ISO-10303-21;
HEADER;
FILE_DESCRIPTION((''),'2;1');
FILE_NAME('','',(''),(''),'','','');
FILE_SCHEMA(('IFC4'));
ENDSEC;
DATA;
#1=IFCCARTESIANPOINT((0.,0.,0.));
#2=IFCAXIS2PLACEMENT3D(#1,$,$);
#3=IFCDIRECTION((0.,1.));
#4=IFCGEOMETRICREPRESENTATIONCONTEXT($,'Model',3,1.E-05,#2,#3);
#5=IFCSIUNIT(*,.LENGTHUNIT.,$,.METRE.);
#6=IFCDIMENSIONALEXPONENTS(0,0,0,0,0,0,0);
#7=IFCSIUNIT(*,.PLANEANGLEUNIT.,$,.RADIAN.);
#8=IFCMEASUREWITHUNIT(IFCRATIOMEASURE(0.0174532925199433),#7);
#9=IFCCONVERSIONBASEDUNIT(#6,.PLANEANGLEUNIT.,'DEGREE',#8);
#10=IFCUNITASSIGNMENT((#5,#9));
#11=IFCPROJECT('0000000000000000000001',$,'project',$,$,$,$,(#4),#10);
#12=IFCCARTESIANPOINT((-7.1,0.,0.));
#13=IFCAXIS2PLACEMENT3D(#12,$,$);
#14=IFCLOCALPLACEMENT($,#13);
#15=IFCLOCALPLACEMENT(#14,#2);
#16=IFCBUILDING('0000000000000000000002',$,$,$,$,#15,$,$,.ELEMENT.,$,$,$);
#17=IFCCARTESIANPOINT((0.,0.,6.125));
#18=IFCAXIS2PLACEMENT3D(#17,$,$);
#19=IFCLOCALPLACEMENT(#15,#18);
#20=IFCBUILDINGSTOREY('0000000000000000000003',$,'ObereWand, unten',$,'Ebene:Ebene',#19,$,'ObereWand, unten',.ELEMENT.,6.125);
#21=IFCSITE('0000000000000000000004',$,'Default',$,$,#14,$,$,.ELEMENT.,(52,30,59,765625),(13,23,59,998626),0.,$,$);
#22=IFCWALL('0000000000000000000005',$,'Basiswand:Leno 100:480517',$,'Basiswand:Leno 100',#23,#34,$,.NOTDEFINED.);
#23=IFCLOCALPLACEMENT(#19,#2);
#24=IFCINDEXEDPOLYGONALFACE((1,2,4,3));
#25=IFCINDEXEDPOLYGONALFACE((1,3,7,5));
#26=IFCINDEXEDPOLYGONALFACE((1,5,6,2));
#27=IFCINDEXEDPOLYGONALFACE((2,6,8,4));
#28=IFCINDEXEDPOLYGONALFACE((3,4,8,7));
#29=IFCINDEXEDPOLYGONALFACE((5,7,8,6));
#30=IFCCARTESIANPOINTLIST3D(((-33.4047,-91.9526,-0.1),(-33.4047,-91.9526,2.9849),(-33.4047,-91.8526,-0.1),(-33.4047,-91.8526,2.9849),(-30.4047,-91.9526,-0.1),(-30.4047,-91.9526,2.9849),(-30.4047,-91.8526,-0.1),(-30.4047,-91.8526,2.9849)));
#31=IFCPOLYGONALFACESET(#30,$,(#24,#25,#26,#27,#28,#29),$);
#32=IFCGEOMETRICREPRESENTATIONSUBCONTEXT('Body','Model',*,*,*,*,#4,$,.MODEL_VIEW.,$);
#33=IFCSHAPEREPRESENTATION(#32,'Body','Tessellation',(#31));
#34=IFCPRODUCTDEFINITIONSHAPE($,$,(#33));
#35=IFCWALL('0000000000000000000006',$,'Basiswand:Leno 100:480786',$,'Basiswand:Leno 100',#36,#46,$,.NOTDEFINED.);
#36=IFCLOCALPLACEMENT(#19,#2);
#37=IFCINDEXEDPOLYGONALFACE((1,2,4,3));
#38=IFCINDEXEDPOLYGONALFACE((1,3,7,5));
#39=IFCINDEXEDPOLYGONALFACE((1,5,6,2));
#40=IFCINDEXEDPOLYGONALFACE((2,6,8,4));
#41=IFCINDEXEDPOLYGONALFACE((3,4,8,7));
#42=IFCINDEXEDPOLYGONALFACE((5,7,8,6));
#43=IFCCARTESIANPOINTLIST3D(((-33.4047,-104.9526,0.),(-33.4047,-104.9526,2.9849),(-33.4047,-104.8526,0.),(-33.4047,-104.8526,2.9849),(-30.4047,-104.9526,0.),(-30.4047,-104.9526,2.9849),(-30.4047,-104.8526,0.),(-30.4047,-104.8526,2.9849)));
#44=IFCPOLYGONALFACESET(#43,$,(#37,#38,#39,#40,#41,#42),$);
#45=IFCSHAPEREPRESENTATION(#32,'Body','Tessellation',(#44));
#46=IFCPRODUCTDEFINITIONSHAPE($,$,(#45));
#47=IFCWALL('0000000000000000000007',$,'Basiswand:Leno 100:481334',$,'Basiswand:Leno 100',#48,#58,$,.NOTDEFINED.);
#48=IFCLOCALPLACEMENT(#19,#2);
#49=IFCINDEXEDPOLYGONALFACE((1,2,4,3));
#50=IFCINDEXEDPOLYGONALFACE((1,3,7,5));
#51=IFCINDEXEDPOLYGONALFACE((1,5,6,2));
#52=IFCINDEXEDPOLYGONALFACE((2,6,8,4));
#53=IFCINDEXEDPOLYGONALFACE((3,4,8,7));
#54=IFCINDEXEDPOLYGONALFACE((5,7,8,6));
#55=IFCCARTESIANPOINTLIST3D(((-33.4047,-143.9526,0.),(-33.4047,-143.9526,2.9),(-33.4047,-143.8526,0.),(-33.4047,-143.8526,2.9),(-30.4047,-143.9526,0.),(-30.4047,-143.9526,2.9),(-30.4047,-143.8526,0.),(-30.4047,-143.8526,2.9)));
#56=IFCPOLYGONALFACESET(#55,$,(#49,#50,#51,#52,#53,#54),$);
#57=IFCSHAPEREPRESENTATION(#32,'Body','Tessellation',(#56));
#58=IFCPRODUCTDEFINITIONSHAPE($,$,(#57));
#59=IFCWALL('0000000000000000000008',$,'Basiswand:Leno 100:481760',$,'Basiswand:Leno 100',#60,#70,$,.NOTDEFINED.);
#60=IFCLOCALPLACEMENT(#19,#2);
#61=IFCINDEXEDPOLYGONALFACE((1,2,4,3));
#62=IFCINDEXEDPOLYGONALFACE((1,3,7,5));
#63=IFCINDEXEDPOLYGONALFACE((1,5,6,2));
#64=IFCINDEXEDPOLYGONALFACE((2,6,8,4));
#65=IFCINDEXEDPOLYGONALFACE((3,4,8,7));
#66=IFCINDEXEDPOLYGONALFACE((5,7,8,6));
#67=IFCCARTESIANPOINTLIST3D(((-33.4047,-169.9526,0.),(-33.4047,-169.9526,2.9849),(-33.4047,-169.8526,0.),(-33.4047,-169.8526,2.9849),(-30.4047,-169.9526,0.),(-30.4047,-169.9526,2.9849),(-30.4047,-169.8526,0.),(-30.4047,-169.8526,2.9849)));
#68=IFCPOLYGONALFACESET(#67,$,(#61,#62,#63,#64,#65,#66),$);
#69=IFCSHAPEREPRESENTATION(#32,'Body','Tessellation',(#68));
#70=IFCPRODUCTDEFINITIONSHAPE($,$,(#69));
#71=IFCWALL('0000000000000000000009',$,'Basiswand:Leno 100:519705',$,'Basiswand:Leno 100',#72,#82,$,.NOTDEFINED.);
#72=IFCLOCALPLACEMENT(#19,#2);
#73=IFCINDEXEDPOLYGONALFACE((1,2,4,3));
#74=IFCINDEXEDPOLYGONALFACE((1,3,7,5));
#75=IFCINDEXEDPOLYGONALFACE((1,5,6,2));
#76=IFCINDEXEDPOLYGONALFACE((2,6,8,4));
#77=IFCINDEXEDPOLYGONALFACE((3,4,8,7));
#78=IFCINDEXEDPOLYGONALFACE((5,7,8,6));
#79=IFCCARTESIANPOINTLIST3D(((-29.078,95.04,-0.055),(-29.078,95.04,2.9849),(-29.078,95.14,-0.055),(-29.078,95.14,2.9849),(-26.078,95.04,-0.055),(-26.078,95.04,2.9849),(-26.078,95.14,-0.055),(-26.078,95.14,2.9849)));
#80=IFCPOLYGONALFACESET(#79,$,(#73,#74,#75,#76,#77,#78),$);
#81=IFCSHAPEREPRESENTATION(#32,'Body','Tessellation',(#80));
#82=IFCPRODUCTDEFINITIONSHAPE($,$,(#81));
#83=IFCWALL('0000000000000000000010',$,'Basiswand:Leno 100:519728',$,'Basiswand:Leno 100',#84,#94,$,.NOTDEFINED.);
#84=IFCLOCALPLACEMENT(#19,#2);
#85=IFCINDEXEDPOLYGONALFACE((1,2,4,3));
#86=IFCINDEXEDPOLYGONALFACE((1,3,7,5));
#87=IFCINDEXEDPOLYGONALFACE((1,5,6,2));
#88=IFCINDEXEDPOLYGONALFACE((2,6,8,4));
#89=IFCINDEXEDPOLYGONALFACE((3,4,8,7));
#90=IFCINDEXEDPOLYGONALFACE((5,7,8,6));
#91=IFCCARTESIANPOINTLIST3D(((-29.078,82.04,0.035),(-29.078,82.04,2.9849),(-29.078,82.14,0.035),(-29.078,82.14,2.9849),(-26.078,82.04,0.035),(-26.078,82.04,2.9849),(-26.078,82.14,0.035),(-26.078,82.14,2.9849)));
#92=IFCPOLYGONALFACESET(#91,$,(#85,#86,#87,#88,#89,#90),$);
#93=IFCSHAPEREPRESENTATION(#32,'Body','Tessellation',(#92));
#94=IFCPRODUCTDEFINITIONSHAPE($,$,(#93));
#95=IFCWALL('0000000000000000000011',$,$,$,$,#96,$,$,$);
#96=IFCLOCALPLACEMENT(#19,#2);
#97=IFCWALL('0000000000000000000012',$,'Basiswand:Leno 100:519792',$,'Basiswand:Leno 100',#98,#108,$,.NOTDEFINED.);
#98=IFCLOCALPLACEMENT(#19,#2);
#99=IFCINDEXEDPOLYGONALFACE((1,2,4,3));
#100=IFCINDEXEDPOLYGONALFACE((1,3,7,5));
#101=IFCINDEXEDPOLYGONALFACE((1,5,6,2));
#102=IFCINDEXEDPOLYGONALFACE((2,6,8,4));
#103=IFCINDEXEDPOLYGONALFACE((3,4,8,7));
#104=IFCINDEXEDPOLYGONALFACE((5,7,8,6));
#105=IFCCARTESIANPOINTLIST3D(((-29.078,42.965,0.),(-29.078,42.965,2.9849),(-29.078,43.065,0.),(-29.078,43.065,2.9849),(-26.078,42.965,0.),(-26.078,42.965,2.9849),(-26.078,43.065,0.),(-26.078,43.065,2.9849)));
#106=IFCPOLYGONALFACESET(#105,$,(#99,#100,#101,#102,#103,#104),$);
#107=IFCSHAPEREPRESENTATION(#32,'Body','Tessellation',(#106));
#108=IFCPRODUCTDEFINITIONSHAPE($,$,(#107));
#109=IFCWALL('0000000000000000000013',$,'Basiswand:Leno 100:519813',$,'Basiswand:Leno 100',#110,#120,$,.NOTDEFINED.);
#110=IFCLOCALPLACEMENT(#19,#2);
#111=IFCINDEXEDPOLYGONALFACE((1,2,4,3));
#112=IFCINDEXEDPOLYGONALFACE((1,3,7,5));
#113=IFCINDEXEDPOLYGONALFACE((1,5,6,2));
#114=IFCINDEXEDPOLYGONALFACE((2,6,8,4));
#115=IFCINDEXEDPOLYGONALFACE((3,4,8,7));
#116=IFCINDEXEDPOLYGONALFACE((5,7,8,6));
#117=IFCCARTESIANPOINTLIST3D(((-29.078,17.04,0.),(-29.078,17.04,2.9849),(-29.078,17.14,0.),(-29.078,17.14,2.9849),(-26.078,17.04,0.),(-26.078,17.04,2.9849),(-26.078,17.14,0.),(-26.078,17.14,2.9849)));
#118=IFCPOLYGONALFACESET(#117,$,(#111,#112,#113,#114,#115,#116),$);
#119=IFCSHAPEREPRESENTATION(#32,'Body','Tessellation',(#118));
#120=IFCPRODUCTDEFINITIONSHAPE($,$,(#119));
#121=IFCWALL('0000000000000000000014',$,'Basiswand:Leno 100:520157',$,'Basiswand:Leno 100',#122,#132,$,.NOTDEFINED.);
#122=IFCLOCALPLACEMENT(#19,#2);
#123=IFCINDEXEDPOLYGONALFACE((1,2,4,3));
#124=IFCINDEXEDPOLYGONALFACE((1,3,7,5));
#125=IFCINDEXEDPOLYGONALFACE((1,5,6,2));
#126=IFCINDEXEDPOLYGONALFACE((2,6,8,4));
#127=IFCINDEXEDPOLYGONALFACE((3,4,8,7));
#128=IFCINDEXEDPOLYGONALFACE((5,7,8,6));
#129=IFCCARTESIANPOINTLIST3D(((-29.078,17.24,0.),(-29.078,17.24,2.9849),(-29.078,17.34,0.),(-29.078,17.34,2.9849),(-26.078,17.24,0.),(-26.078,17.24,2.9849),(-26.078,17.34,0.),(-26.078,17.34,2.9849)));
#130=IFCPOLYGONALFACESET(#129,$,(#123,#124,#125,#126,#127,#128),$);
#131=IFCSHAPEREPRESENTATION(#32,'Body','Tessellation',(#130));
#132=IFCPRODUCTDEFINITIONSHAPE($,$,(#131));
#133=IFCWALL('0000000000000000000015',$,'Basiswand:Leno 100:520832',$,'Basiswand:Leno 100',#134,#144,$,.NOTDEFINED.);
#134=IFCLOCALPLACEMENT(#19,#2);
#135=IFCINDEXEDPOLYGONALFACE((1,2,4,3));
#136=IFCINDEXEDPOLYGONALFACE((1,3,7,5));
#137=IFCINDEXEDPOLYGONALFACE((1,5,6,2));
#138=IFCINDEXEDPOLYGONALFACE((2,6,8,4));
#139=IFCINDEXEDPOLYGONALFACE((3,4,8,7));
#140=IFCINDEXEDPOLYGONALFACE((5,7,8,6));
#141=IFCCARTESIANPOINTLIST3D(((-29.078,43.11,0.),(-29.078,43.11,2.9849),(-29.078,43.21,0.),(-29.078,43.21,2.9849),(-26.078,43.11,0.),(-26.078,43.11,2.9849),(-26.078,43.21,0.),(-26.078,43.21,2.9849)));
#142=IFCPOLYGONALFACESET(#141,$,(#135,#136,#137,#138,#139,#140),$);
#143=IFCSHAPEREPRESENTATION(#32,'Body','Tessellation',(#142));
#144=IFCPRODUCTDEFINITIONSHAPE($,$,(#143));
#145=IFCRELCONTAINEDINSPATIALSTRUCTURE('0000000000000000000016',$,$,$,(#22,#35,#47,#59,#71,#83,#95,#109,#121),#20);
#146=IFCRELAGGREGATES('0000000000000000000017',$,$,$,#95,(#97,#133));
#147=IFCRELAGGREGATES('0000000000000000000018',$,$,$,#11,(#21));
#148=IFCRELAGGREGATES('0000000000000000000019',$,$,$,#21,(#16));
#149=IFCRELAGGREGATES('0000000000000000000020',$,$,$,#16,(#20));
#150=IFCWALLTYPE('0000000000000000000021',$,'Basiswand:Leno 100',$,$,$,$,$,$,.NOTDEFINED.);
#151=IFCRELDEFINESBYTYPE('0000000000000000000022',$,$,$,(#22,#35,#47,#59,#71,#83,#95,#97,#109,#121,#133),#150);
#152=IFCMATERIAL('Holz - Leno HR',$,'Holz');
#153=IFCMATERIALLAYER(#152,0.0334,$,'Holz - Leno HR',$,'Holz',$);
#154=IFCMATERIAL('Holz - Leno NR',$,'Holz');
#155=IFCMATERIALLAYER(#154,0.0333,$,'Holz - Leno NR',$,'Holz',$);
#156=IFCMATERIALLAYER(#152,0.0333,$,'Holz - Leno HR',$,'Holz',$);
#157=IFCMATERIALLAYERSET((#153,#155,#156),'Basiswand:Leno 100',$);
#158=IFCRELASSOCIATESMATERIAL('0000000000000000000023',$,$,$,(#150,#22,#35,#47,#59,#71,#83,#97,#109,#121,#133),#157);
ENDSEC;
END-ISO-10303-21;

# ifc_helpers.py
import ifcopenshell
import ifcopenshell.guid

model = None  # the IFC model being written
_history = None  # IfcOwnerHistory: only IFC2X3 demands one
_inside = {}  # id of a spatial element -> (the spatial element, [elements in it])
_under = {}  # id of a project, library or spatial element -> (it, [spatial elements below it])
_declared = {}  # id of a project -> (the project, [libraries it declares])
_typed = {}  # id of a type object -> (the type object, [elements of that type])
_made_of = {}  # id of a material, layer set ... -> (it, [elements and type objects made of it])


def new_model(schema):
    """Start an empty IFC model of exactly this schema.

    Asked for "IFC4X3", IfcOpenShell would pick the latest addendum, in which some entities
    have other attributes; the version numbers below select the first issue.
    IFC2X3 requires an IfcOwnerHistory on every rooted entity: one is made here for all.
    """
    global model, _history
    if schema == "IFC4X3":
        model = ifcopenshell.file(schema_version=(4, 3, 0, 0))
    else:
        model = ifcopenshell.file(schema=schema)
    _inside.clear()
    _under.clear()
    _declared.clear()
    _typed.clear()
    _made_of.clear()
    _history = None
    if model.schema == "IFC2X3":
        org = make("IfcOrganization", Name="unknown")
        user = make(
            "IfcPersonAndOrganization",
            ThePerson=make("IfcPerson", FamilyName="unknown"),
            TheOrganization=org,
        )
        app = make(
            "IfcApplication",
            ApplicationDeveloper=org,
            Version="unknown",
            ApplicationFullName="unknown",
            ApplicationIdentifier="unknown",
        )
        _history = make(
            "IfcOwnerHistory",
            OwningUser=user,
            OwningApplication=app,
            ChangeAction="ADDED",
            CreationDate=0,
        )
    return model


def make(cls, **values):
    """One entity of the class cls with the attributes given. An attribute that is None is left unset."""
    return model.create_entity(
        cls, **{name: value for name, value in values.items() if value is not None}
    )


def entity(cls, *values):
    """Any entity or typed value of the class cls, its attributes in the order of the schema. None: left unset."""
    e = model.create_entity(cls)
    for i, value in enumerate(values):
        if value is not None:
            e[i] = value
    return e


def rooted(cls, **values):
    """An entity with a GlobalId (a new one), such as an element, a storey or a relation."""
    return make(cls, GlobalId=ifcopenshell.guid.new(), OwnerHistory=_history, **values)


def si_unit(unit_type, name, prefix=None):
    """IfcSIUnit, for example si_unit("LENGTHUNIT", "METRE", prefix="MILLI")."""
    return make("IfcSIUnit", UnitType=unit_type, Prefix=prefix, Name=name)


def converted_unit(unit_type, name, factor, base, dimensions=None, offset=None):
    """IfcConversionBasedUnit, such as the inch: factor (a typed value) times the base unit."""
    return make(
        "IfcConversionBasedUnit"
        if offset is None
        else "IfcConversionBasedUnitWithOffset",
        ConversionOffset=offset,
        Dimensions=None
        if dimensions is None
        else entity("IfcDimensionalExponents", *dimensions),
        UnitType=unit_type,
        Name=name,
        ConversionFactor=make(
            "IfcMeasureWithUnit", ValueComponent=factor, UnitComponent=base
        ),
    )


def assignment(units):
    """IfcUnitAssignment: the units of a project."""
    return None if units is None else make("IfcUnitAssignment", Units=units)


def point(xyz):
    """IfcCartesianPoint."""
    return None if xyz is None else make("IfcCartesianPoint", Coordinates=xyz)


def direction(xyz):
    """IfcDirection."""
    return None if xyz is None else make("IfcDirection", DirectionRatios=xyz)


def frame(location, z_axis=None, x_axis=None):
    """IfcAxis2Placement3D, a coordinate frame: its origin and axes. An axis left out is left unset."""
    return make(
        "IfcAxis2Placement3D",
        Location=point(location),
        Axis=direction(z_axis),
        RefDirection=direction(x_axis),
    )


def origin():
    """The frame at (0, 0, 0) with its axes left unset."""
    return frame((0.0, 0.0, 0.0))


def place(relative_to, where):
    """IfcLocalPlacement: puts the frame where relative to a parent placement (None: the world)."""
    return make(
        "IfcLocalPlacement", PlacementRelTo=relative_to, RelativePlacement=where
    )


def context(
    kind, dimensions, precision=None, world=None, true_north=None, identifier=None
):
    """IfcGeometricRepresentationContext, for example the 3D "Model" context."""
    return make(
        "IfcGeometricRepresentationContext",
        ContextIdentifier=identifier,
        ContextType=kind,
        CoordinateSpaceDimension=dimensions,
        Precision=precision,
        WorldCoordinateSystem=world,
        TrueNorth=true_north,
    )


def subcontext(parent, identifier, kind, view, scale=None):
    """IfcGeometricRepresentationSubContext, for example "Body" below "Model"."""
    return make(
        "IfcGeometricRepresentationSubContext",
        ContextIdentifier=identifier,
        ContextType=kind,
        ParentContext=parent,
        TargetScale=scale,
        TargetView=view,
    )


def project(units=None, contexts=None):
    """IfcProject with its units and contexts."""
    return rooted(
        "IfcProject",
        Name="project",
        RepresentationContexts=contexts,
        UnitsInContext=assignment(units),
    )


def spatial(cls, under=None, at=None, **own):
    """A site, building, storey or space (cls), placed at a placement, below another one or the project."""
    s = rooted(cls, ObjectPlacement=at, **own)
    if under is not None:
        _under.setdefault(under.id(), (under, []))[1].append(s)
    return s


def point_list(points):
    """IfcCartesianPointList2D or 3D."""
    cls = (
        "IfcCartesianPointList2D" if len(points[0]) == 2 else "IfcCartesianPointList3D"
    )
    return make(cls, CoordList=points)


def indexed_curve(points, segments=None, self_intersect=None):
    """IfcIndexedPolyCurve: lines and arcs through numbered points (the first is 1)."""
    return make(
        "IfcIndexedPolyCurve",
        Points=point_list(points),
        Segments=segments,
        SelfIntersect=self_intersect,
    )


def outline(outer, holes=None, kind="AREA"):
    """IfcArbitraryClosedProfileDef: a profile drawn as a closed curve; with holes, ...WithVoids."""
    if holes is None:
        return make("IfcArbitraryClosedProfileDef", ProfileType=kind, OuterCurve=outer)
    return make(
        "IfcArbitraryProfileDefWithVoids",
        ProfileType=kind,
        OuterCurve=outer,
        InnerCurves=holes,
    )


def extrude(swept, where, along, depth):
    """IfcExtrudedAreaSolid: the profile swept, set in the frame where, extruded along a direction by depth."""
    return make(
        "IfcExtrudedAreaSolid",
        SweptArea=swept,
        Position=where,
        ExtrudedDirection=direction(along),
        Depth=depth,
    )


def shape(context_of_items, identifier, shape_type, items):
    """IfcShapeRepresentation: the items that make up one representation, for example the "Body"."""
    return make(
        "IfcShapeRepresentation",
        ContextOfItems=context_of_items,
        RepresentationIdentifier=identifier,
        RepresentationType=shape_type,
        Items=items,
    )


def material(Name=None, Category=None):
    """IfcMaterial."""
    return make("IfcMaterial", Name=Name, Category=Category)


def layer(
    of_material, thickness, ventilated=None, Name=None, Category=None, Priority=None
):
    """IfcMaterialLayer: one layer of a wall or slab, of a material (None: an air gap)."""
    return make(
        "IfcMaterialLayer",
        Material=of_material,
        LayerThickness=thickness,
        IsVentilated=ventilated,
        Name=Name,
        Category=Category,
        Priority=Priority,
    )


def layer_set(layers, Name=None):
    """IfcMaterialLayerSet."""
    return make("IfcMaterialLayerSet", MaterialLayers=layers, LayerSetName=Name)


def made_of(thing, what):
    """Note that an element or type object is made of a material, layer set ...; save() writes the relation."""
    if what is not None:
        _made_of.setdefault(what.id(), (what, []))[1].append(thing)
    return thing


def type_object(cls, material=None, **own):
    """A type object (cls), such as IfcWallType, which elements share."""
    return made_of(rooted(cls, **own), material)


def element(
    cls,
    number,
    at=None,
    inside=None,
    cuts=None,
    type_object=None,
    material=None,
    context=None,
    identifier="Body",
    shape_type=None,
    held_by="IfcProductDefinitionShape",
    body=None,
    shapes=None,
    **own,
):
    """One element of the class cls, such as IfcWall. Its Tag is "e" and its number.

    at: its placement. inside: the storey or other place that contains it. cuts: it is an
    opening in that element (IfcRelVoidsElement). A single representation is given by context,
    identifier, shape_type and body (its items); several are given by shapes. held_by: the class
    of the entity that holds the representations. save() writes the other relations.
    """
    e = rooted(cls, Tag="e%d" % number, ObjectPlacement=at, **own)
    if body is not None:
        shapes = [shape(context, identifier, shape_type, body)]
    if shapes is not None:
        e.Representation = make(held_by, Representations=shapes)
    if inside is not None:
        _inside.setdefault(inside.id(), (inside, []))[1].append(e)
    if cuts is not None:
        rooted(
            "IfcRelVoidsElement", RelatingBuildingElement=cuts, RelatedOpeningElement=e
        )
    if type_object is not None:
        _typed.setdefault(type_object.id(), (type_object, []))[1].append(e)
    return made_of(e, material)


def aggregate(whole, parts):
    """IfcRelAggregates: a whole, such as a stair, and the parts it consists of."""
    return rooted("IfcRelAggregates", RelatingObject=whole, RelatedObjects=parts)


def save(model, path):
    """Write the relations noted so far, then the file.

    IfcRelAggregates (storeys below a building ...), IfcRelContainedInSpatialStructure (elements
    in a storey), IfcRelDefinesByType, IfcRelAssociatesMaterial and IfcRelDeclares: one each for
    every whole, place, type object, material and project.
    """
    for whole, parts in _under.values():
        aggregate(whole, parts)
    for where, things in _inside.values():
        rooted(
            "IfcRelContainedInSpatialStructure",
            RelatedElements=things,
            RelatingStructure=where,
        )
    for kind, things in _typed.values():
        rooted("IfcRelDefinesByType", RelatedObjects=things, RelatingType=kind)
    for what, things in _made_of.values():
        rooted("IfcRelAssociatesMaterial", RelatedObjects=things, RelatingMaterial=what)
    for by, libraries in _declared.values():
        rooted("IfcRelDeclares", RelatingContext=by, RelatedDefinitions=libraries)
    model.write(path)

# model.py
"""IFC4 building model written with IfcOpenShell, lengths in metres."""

from ifc_helpers import new_model, entity, si_unit, converted_unit, direction, frame, origin, place, context, subcontext, project, spatial, indexed_curve, outline, extrude, material, layer, layer_set, type_object, element, aggregate, save


model = new_model("IFC4")

# Units and contexts
model_context = context("Model", 3, precision=1e-05, world=origin(), true_north=direction((0.0, 1.0)))
body_context = subcontext(model_context, "Body", "Model", "MODEL_VIEW")
ifc_project = project(units=[si_unit("LENGTHUNIT", "METRE"), converted_unit("PLANEANGLEUNIT", "DEGREE", entity("IfcRatioMeasure", 0.0174532925199433), si_unit("PLANEANGLEUNIT", "RADIAN"), dimensions=[0, 0, 0, 0, 0, 0, 0])], contexts=[model_context])

# Site, building, storey
site_placement = place(None, frame((-7.1, 0.0, 0.0)))
site = spatial("IfcSite", under=ifc_project, at=site_placement, Name="Default", CompositionType="ELEMENT", RefLatitude=(52, 30, 59, 765625), RefLongitude=(13, 23, 59, 998626), RefElevation=0.0)
building_placement = place(site_placement, origin())
building = spatial("IfcBuilding", under=site, at=building_placement, CompositionType="ELEMENT")
storey_placement = place(building_placement, frame((0.0, 0.0, 6.125)))
storey = spatial("IfcBuildingStorey", under=building, at=storey_placement, Name="ObereWand, unten", ObjectType="Ebene:Ebene", LongName="ObereWand, unten", CompositionType="ELEMENT", Elevation=6.125)

# Shared definitions
ifc_material_1 = material(Name="Holz - Leno HR", Category="Holz")
ifc_material_2 = material(Name="Holz - Leno NR", Category="Holz")

# Walls
ifc_layer_1 = layer(ifc_material_1, 0.0334, Name="Holz - Leno HR", Category="Holz")
ifc_layer_2 = layer(ifc_material_2, 0.0333, Name="Holz - Leno NR", Category="Holz")
ifc_layer_3 = layer(ifc_material_1, 0.0333, Name="Holz - Leno HR", Category="Holz")
ifc_layer_set_1 = layer_set([ifc_layer_1, ifc_layer_2, ifc_layer_3], Name="Basiswand:Leno 100")
wall_type = type_object("IfcWallType", Name="Basiswand:Leno 100", PredefinedType="NOTDEFINED", material=ifc_layer_set_1)
wall_1_placement = place(storey_placement, frame((-30.4047, -91.9026, -0.1), z_axis=(0.0, 0.0, 1.0), x_axis=(-1.0, 0.0, 0.0)))
element("IfcWall", 1, at=wall_1_placement, inside=storey, type_object=wall_type, material=ifc_layer_set_1, Name="Basiswand:Leno 100:480517", ObjectType="Basiswand:Leno 100", PredefinedType="NOTDEFINED", context=body_context, shape_type="SweptSolid", body=[
    extrude(outline(indexed_curve([(3.0, 0.05), (0.0, 0.05), (0.0, -0.05), (3.0, -0.05), (3.0, 0.05)], self_intersect=False)), origin(), (0.0, 0.0, 1.0), 3.0849),
])
wall_2_placement = place(storey_placement, frame((-30.4047, -104.9026, 0.0), z_axis=(0.0, 0.0, 1.0), x_axis=(-1.0, 0.0, 0.0)))
element("IfcWall", 2, at=wall_2_placement, inside=storey, type_object=wall_type, material=ifc_layer_set_1, Name="Basiswand:Leno 100:480786", ObjectType="Basiswand:Leno 100", PredefinedType="NOTDEFINED", context=body_context, shape_type="SweptSolid", body=[
    extrude(outline(indexed_curve([(3.0, 0.05), (0.0, 0.05), (0.0, -0.05), (3.0, -0.05), (3.0, 0.05)], self_intersect=False)), origin(), (0.0, 0.0, 1.0), 2.9849),
])
wall_3_placement = place(storey_placement, frame((-30.4047, -143.9026, 0.0), z_axis=(0.0, 0.0, 1.0), x_axis=(-1.0, 0.0, 0.0)))
element("IfcWall", 3, at=wall_3_placement, inside=storey, type_object=wall_type, material=ifc_layer_set_1, Name="Basiswand:Leno 100:481334", ObjectType="Basiswand:Leno 100", PredefinedType="NOTDEFINED", context=body_context, shape_type="SweptSolid", body=[
    extrude(outline(indexed_curve([(3.0, 0.05), (0.0, 0.05), (0.0, -0.05), (3.0, -0.05), (3.0, 0.05)], self_intersect=False)), origin(), (0.0, 0.0, 1.0), 2.9),
])
wall_4_placement = place(storey_placement, frame((-30.4047, -169.9026, 0.0), z_axis=(0.0, 0.0, 1.0), x_axis=(-1.0, 0.0, 0.0)))
element("IfcWall", 4, at=wall_4_placement, inside=storey, type_object=wall_type, material=ifc_layer_set_1, Name="Basiswand:Leno 100:481760", ObjectType="Basiswand:Leno 100", PredefinedType="NOTDEFINED", context=body_context, shape_type="SweptSolid", body=[
    extrude(outline(indexed_curve([(3.0, 0.05), (0.0, 0.05), (0.0, -0.05), (3.0, -0.05), (3.0, 0.05)], self_intersect=False)), origin(), (0.0, 0.0, 1.0), 2.9849),
])
wall_5_placement = place(storey_placement, frame((-26.078, 95.09, -0.055), z_axis=(0.0, 0.0, 1.0), x_axis=(-1.0, 0.0, 0.0)))
element("IfcWall", 5, at=wall_5_placement, inside=storey, type_object=wall_type, material=ifc_layer_set_1, Name="Basiswand:Leno 100:519705", ObjectType="Basiswand:Leno 100", PredefinedType="NOTDEFINED", context=body_context, shape_type="SweptSolid", body=[
    extrude(outline(indexed_curve([(3.0, 0.05), (0.0, 0.05), (0.0, -0.05), (3.0, -0.05), (3.0, 0.05)], self_intersect=False)), origin(), (0.0, 0.0, 1.0), 3.0399),
])
wall_6_placement = place(storey_placement, frame((-26.078, 82.09, 0.035), z_axis=(0.0, 0.0, 1.0), x_axis=(-1.0, 0.0, 0.0)))
element("IfcWall", 6, at=wall_6_placement, inside=storey, type_object=wall_type, material=ifc_layer_set_1, Name="Basiswand:Leno 100:519728", ObjectType="Basiswand:Leno 100", PredefinedType="NOTDEFINED", context=body_context, shape_type="SweptSolid", body=[
    extrude(outline(indexed_curve([(3.0, 0.05), (0.0, 0.05), (0.0, -0.05), (3.0, -0.05), (3.0, 0.05)], self_intersect=False)), origin(), (0.0, 0.0, 1.0), 2.9499),
])
wall_7 = element("IfcWall", 7, inside=storey, type_object=wall_type)
wall_8_placement = place(storey_placement, frame((-26.078, 43.015, 0.0), z_axis=(0.0, 0.0, 1.0), x_axis=(-1.0, 0.0, 0.0)))
wall_8 = element("IfcWall", 8, at=wall_8_placement, type_object=wall_type, material=ifc_layer_set_1, Name="Basiswand:Leno 100:519792", ObjectType="Basiswand:Leno 100", PredefinedType="NOTDEFINED", context=body_context, shape_type="SweptSolid", body=[
    extrude(outline(indexed_curve([(3.0, 0.05), (0.0, 0.05), (0.0, -0.05), (3.0, -0.05), (3.0, 0.05)], self_intersect=False)), origin(), (0.0, 0.0, 1.0), 2.9849),
])
for number, where, z_axis, x_axis, name in (
    (9, (-26.078, 17.09, 0.0), (0.0, 0.0, 1.0), (-1.0, 0.0, 0.0), "Basiswand:Leno 100:519813"),
    (10, (-26.078, 17.29, 0.0), (0.0, 0.0, 1.0), (-1.0, 0.0, 0.0), "Basiswand:Leno 100:520157"),
):
    element("IfcWall", number, at=place(storey_placement, frame(where, z_axis=z_axis, x_axis=x_axis)), inside=storey, type_object=wall_type, material=ifc_layer_set_1, Name=name, ObjectType="Basiswand:Leno 100", PredefinedType="NOTDEFINED", context=body_context, shape_type="SweptSolid", body=[
        extrude(outline(indexed_curve([(3.0, 0.05), (0.0, 0.05), (0.0, -0.05), (3.0, -0.05), (3.0, 0.05)], self_intersect=False)), origin(), (0.0, 0.0, 1.0), 2.9849),
    ])

# Wall
wall_9_placement = place(storey_placement, frame((-26.078, 43.16, 0.0), z_axis=(0.0, 0.0, 1.0), x_axis=(-1.0, 0.0, 0.0)))
wall_9 = element("IfcWall", 11, at=wall_9_placement, type_object=wall_type, material=ifc_layer_set_1, Name="Basiswand:Leno 100:520832", ObjectType="Basiswand:Leno 100", PredefinedType="NOTDEFINED", context=body_context, shape_type="SweptSolid", body=[
    extrude(outline(indexed_curve([(3.0, 0.05), (0.0, 0.05), (0.0, -0.05), (3.0, -0.05), (3.0, 0.05)], self_intersect=False)), origin(), (0.0, 0.0, 1.0), 2.9849),
])
aggregate(wall_7, [wall_8, wall_9])

save(model, "model.ifc")
